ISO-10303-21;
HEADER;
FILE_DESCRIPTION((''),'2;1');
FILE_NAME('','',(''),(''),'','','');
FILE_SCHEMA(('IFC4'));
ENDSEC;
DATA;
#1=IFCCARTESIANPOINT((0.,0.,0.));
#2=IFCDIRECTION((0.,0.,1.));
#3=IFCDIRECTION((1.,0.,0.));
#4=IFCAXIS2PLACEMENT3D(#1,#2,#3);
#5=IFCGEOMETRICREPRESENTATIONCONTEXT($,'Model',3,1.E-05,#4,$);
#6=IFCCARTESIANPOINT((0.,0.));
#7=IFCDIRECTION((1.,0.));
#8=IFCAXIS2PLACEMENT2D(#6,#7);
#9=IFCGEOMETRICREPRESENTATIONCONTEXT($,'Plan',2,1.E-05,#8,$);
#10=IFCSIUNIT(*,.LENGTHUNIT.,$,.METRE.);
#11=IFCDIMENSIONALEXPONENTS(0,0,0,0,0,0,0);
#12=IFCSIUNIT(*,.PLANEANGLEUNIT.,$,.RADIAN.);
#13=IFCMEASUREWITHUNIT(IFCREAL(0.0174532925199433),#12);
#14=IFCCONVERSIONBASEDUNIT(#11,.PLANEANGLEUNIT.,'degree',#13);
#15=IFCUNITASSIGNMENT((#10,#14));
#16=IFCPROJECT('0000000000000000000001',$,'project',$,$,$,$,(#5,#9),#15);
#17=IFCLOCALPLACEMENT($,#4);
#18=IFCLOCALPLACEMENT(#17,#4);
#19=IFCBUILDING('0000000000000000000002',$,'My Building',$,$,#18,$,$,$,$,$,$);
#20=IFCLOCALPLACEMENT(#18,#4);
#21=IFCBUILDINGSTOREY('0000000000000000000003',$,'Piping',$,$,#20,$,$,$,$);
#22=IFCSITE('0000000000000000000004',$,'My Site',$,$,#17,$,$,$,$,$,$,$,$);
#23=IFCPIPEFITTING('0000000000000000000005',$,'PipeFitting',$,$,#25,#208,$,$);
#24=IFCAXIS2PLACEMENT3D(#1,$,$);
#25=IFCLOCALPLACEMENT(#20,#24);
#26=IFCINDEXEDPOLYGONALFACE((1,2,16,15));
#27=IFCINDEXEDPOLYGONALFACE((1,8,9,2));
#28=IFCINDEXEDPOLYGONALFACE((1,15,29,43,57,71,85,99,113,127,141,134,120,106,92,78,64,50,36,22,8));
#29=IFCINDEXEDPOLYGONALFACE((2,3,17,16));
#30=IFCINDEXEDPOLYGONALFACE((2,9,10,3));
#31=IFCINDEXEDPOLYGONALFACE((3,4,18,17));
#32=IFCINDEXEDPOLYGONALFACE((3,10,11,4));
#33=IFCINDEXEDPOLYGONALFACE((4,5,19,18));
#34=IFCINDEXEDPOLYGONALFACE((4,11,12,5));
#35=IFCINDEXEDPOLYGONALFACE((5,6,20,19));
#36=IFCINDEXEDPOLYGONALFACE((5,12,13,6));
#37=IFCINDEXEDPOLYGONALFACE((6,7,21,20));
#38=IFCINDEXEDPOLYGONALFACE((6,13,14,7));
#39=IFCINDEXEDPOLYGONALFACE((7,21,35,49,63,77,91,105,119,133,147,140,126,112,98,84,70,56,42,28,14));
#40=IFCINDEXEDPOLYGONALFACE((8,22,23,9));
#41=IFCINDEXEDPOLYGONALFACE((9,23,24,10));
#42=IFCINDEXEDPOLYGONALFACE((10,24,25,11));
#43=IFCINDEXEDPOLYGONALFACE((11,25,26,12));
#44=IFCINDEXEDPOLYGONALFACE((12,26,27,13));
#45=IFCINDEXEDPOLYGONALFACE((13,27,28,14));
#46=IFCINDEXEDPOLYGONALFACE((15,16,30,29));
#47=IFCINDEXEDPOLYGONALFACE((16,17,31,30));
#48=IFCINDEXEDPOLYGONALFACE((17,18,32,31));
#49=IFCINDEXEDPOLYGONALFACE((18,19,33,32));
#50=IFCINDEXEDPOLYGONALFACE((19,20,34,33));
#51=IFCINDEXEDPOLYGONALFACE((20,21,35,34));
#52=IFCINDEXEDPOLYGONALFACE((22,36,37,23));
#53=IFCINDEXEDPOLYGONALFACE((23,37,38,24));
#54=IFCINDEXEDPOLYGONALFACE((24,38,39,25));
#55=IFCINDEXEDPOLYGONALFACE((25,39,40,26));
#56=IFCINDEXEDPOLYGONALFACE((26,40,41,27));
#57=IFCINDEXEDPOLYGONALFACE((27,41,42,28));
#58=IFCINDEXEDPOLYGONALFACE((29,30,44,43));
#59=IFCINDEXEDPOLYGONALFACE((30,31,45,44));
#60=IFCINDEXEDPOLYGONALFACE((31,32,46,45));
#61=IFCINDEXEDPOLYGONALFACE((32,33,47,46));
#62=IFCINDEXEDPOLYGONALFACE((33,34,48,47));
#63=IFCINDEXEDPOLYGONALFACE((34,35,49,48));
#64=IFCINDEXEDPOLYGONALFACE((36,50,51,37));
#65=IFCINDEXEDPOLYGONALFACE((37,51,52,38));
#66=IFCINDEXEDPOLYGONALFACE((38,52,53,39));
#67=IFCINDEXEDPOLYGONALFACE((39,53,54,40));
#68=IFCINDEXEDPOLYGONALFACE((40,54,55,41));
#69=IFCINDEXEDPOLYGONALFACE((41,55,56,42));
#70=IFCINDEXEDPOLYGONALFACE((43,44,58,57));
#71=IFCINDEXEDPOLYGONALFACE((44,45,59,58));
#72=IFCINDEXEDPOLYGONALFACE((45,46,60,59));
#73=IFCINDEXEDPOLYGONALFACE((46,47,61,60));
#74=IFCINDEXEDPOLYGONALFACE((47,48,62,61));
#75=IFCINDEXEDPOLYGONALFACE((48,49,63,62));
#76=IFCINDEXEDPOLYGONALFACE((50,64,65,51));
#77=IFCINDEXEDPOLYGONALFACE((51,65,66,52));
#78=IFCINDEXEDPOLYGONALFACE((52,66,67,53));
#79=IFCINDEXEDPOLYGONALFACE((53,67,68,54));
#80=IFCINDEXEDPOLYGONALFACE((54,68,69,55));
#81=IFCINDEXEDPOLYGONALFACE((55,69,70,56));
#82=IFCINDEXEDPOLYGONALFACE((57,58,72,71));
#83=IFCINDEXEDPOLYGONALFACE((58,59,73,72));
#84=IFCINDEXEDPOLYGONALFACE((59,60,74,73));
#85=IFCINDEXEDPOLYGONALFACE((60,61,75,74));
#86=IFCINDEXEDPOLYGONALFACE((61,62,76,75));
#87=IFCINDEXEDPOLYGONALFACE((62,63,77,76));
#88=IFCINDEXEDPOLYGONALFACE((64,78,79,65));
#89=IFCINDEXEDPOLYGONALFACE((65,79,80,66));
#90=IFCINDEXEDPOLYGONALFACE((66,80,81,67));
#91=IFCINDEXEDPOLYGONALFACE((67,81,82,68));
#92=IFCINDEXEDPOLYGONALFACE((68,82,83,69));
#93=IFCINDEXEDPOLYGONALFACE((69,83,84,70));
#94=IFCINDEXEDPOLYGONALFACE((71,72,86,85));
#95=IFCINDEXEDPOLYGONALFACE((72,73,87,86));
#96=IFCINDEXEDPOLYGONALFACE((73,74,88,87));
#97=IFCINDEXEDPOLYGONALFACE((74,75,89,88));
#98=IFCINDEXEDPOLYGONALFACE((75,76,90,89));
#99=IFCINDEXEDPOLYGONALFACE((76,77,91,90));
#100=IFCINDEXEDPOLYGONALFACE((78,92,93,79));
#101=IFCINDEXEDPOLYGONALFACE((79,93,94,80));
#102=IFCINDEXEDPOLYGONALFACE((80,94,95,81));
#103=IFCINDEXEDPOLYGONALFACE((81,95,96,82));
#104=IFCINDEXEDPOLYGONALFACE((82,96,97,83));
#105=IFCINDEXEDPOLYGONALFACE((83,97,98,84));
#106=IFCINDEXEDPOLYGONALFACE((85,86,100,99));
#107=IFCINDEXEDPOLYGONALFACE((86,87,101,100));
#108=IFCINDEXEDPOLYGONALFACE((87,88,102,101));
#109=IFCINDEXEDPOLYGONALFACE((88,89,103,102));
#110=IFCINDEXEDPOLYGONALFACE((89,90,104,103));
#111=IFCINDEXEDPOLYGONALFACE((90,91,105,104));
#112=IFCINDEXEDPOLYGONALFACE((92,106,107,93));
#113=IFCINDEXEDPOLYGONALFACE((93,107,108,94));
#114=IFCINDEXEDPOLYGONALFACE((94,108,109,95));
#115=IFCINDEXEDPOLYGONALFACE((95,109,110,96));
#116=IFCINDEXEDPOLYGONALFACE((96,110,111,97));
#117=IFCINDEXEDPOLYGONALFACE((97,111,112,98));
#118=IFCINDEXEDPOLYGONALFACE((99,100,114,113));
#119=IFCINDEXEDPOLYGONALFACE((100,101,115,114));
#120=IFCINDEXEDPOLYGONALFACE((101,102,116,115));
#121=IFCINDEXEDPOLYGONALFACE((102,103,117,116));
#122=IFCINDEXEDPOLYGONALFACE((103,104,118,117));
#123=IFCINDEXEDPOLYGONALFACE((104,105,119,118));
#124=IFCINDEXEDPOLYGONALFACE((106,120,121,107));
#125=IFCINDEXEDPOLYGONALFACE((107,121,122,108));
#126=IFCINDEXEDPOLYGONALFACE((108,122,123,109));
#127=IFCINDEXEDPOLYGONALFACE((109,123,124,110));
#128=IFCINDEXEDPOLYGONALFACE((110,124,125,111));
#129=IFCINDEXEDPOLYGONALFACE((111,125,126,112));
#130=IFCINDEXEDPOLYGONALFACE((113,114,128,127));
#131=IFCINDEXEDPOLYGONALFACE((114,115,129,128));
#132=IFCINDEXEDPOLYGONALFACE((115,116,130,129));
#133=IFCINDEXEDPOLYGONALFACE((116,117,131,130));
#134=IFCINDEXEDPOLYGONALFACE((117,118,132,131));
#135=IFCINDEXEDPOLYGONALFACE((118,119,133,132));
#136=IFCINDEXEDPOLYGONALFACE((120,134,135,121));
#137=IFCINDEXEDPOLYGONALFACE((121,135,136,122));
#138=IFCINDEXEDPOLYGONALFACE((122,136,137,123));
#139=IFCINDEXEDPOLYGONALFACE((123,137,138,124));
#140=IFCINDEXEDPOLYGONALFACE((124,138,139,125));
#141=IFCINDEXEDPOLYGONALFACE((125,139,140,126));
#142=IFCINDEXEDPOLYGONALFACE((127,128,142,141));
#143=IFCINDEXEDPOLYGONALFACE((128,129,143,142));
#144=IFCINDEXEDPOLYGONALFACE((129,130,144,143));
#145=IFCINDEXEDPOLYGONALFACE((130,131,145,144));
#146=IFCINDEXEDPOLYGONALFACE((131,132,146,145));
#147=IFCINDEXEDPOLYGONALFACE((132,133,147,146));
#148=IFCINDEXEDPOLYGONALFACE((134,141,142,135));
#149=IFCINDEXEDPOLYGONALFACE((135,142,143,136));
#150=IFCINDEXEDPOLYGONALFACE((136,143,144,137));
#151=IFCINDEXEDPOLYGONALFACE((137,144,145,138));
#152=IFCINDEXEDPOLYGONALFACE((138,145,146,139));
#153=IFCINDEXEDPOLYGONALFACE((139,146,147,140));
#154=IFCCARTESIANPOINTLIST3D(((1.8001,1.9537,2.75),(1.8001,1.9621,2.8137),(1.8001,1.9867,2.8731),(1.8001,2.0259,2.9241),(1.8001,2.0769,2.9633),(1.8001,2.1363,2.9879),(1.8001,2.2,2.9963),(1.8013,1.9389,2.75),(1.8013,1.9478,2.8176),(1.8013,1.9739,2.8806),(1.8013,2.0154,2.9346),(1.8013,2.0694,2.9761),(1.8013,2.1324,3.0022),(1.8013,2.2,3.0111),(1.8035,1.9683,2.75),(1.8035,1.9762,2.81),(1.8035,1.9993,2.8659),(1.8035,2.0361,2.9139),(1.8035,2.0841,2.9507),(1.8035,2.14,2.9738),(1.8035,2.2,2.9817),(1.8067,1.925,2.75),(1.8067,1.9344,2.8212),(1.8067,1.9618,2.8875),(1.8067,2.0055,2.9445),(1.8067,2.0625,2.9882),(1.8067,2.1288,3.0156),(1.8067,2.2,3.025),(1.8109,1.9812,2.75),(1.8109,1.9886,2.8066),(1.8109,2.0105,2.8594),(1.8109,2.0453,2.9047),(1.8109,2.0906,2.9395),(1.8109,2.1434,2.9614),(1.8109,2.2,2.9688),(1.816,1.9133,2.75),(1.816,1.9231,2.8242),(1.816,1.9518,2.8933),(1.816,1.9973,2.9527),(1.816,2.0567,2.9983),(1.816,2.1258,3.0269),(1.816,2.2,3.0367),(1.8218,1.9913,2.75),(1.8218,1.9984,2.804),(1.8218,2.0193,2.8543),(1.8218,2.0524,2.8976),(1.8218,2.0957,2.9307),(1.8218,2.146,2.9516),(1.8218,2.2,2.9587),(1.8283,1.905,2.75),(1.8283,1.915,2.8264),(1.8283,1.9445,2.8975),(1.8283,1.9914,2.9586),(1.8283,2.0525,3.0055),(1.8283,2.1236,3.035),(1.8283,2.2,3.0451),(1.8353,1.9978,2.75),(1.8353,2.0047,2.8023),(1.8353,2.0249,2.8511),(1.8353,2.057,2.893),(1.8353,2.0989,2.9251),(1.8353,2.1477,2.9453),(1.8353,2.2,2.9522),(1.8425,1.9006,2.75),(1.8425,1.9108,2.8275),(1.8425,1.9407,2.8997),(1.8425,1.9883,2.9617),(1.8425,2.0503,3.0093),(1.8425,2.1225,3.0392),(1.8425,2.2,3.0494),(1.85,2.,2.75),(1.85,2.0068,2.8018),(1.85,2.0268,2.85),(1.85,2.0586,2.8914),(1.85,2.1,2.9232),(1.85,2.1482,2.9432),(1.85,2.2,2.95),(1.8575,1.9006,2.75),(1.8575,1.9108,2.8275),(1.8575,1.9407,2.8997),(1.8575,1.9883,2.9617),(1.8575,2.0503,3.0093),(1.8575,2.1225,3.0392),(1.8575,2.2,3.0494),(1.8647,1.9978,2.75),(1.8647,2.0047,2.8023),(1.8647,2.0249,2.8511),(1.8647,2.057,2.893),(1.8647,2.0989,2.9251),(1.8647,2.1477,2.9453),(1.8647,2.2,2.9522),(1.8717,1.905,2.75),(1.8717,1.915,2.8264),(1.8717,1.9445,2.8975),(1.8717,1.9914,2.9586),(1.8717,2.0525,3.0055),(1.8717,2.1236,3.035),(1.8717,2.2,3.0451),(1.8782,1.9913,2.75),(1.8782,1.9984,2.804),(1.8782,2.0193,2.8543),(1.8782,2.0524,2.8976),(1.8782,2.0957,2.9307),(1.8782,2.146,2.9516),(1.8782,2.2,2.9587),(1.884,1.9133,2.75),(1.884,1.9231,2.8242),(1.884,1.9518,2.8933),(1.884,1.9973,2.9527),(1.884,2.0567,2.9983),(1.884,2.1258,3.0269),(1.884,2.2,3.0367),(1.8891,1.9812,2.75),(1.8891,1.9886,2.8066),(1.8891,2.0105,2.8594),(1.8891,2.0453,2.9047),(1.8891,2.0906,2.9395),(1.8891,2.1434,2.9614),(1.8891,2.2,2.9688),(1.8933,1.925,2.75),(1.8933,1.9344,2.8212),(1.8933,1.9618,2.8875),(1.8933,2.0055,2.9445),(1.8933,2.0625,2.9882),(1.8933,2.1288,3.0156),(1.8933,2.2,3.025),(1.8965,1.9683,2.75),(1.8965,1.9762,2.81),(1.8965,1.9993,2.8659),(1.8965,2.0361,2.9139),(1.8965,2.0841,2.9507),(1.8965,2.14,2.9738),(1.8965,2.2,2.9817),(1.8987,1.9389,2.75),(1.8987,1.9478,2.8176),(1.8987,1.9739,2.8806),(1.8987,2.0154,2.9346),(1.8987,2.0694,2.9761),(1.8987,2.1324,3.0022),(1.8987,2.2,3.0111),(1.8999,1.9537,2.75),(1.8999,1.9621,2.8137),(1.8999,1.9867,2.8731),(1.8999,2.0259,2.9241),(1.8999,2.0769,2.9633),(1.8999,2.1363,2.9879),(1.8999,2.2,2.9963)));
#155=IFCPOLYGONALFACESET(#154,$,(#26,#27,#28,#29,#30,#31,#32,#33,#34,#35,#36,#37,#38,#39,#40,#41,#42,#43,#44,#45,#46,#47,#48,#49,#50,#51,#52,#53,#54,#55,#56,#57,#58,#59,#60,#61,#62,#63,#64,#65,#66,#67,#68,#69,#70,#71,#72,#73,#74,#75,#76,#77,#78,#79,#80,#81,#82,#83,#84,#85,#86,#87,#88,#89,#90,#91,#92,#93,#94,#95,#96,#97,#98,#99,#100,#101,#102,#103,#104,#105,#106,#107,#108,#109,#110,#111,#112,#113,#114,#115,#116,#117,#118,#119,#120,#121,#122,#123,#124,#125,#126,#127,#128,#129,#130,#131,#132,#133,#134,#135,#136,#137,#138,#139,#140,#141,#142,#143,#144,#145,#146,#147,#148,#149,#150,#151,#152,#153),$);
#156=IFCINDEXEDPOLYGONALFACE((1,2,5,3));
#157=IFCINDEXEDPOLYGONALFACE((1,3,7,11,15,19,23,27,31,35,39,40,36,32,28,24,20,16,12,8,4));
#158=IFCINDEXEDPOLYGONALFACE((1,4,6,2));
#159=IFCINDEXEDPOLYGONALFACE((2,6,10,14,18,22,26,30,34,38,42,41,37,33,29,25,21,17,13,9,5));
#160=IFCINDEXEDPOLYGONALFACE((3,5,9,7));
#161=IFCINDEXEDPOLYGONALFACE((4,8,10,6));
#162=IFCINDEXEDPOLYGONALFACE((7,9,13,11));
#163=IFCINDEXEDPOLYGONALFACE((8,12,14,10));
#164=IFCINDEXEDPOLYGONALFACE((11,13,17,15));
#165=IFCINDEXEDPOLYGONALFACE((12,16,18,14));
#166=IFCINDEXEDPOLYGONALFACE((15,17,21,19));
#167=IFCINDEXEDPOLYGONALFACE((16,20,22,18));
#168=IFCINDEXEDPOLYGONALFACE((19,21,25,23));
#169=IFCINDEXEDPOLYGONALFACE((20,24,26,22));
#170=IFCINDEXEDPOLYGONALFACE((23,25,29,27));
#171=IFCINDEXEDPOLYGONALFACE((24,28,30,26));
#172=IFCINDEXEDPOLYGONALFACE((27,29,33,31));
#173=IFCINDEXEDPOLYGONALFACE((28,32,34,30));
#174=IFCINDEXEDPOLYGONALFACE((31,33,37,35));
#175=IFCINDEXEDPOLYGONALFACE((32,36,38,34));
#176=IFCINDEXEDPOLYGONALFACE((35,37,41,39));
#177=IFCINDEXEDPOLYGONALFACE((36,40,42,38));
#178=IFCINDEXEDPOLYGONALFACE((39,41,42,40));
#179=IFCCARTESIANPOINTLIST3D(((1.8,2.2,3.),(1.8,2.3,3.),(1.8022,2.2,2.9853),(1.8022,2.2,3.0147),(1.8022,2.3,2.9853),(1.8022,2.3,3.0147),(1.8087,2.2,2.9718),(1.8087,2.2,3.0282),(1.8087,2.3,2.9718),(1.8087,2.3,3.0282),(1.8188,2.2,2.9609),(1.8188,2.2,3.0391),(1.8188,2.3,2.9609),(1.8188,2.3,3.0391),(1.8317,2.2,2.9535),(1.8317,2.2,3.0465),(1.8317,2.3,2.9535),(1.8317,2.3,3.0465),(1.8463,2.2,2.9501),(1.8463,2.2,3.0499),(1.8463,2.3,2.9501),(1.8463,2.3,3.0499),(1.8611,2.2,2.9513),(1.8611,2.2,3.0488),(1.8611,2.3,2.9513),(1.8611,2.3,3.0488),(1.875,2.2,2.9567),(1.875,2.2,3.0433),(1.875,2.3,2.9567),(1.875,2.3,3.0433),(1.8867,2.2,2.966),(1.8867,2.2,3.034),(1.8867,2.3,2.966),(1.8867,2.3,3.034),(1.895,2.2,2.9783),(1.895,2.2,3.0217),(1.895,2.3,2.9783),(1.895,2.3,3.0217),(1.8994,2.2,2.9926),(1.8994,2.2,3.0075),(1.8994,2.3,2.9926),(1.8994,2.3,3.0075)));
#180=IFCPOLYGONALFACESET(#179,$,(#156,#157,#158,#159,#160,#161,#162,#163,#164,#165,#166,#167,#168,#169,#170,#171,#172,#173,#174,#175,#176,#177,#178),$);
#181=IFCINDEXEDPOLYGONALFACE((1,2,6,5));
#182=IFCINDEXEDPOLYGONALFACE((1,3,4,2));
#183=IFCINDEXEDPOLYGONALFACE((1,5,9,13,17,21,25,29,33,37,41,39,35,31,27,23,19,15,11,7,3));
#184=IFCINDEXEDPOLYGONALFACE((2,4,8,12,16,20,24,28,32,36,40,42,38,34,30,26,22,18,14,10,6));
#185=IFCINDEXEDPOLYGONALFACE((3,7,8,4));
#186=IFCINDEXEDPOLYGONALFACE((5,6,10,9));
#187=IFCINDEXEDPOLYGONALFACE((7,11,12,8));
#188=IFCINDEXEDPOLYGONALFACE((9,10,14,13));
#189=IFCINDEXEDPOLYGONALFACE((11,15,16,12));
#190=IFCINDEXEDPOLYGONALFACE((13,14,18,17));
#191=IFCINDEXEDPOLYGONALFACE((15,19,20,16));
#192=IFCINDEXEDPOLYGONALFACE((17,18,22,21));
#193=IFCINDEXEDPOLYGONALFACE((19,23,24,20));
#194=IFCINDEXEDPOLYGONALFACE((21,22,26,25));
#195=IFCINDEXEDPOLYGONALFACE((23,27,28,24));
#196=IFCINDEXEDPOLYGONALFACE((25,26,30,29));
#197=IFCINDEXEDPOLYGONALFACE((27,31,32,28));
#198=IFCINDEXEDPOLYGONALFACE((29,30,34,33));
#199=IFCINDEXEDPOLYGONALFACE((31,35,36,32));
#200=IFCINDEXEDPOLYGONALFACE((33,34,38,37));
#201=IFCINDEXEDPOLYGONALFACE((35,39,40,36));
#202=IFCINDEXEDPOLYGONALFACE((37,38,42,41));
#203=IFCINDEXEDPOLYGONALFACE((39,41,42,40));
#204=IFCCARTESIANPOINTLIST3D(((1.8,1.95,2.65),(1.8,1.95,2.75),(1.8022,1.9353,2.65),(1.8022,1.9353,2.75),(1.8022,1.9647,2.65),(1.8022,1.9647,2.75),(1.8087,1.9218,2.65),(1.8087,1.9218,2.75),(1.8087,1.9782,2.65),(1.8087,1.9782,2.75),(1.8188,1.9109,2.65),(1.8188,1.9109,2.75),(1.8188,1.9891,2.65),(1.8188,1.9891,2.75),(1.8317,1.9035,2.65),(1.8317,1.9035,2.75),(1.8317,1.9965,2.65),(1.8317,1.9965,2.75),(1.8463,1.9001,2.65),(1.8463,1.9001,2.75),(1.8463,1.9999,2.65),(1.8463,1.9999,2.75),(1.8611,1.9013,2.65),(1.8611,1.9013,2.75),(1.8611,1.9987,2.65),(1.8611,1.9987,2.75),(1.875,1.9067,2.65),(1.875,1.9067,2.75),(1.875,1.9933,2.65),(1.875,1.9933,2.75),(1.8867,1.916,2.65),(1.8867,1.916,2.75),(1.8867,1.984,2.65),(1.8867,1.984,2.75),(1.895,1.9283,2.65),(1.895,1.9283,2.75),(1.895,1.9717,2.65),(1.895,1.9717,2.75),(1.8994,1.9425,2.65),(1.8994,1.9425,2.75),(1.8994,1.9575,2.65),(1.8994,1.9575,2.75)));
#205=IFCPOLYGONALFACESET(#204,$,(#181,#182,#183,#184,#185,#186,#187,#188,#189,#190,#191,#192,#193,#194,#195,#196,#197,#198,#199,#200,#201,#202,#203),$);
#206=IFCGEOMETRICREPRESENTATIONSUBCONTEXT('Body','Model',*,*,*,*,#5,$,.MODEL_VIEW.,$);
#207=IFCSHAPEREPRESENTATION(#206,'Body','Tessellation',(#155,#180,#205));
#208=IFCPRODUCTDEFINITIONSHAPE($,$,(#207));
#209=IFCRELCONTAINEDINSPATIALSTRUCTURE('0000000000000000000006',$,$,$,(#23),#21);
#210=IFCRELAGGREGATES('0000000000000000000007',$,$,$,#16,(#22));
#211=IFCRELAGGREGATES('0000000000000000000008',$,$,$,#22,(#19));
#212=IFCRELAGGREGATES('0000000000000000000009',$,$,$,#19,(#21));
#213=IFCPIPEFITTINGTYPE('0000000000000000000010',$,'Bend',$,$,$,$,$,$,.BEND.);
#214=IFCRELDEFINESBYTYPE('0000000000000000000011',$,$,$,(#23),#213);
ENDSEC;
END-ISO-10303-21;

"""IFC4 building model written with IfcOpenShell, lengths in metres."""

from ifc_helpers import new_model, entity, si_unit, converted_unit, frame, origin_with_axes, origin_2d_with_axis, place, context, subcontext, project, spatial, line, indexed_curve, circle, outline, extrude, source, transform, mapped, type_object, type_shapes, element, save


model = new_model("IFC4")

# Units and contexts
model_context = context("Model", 3, precision=1e-05, world=origin_with_axes())
plan_context = context("Plan", 2, precision=1e-05, world=origin_2d_with_axis())
body_context = subcontext(model_context, "Body", "Model", "MODEL_VIEW")
ifc_project = project(units=[si_unit("LENGTHUNIT", "METRE"), converted_unit("PLANEANGLEUNIT", "degree", entity("IfcReal", 0.0174532925199433), si_unit("PLANEANGLEUNIT", "RADIAN"), dimensions=[0, 0, 0, 0, 0, 0, 0])], contexts=[model_context, plan_context])

# Site, building, storey
site_placement = place(None, origin_with_axes())
site = spatial("IfcSite", under=ifc_project, at=site_placement, Name="My Site")
building_placement = place(site_placement, origin_with_axes())
building = spatial("IfcBuilding", under=site, at=building_placement, Name="My Building")
storey_placement = place(building_placement, origin_with_axes())
storey = spatial("IfcBuildingStorey", under=building, at=storey_placement, Name="Piping")

# Shared definitions
pipe_fitting_type = type_object("IfcPipeFittingType", Name="Bend", PredefinedType="BEND")
shared_shape = source(origin_with_axes(), body_context, "Body", "SolidModel", [
    entity("IfcSweptDiskSolid", entity("IfcIndexedPolyCurve", entity("IfcCartesianPointList3D", [[0.0, 0.0, -0.1], [0.0, -0.0732, -0.2768], [0.0, -0.25, -0.35]]), [entity("IfcArcIndex", [1, 2, 3])]), 0.05),
    extrude(circle(Radius=0.05), origin_with_axes(), (0.0, 0.0, -1.0), 0.1),
    extrude(circle(Radius=0.05), frame((0.0, -0.25, -0.35), z_axis=(0.0, -1.0, 0.0), x_axis=(1.0, 0.0, 0.0)), (0.0, 0.0, 1.0), 0.1),
])
type_shapes(pipe_fitting_type, [shared_shape])

# Pipe fitting, opening
pipe_fitting_placement = place(storey_placement, frame((1.85, 2.3, 3.0), z_axis=(0.0, 1.0, 0.0), x_axis=(-1.0, 0.0, 0.0)))
pipe_fitting = element("IfcPipeFitting", 1, at=pipe_fitting_placement, inside=storey, type_object=pipe_fitting_type, Name="PipeFitting", context=body_context, shape_type="MappedRepresentation", body=[
    mapped(shared_shape, transform((0.0, 0.0, 0.0), x_axis=(1.0, 0.0, 0.0), y_axis=(0.0, 1.0, 0.0), z_axis=(0.0, 0.0, 1.0), scale=1.0)),
])
opening_placement = place(pipe_fitting_placement, frame((1.85, -3.0, -2.3), z_axis=(0.0, 1.0, 0.0), x_axis=(-1.0, 0.0, 0.0)))
element("IfcOpeningElement", 2, at=opening_placement, cuts=pipe_fitting, PredefinedType="OPENING", context=body_context, shape_type="SweptSolid", body=[
    extrude(outline(indexed_curve([(0.0, 0.0), (0.5, 0.0), (0.5, 0.5), (0.0, 0.5)], segments=[line(1, 2, 3, 4, 1)])), origin_with_axes(), (0.0, 0.0, 1.0), 0.5),
])

save(model, "model.ifc")
